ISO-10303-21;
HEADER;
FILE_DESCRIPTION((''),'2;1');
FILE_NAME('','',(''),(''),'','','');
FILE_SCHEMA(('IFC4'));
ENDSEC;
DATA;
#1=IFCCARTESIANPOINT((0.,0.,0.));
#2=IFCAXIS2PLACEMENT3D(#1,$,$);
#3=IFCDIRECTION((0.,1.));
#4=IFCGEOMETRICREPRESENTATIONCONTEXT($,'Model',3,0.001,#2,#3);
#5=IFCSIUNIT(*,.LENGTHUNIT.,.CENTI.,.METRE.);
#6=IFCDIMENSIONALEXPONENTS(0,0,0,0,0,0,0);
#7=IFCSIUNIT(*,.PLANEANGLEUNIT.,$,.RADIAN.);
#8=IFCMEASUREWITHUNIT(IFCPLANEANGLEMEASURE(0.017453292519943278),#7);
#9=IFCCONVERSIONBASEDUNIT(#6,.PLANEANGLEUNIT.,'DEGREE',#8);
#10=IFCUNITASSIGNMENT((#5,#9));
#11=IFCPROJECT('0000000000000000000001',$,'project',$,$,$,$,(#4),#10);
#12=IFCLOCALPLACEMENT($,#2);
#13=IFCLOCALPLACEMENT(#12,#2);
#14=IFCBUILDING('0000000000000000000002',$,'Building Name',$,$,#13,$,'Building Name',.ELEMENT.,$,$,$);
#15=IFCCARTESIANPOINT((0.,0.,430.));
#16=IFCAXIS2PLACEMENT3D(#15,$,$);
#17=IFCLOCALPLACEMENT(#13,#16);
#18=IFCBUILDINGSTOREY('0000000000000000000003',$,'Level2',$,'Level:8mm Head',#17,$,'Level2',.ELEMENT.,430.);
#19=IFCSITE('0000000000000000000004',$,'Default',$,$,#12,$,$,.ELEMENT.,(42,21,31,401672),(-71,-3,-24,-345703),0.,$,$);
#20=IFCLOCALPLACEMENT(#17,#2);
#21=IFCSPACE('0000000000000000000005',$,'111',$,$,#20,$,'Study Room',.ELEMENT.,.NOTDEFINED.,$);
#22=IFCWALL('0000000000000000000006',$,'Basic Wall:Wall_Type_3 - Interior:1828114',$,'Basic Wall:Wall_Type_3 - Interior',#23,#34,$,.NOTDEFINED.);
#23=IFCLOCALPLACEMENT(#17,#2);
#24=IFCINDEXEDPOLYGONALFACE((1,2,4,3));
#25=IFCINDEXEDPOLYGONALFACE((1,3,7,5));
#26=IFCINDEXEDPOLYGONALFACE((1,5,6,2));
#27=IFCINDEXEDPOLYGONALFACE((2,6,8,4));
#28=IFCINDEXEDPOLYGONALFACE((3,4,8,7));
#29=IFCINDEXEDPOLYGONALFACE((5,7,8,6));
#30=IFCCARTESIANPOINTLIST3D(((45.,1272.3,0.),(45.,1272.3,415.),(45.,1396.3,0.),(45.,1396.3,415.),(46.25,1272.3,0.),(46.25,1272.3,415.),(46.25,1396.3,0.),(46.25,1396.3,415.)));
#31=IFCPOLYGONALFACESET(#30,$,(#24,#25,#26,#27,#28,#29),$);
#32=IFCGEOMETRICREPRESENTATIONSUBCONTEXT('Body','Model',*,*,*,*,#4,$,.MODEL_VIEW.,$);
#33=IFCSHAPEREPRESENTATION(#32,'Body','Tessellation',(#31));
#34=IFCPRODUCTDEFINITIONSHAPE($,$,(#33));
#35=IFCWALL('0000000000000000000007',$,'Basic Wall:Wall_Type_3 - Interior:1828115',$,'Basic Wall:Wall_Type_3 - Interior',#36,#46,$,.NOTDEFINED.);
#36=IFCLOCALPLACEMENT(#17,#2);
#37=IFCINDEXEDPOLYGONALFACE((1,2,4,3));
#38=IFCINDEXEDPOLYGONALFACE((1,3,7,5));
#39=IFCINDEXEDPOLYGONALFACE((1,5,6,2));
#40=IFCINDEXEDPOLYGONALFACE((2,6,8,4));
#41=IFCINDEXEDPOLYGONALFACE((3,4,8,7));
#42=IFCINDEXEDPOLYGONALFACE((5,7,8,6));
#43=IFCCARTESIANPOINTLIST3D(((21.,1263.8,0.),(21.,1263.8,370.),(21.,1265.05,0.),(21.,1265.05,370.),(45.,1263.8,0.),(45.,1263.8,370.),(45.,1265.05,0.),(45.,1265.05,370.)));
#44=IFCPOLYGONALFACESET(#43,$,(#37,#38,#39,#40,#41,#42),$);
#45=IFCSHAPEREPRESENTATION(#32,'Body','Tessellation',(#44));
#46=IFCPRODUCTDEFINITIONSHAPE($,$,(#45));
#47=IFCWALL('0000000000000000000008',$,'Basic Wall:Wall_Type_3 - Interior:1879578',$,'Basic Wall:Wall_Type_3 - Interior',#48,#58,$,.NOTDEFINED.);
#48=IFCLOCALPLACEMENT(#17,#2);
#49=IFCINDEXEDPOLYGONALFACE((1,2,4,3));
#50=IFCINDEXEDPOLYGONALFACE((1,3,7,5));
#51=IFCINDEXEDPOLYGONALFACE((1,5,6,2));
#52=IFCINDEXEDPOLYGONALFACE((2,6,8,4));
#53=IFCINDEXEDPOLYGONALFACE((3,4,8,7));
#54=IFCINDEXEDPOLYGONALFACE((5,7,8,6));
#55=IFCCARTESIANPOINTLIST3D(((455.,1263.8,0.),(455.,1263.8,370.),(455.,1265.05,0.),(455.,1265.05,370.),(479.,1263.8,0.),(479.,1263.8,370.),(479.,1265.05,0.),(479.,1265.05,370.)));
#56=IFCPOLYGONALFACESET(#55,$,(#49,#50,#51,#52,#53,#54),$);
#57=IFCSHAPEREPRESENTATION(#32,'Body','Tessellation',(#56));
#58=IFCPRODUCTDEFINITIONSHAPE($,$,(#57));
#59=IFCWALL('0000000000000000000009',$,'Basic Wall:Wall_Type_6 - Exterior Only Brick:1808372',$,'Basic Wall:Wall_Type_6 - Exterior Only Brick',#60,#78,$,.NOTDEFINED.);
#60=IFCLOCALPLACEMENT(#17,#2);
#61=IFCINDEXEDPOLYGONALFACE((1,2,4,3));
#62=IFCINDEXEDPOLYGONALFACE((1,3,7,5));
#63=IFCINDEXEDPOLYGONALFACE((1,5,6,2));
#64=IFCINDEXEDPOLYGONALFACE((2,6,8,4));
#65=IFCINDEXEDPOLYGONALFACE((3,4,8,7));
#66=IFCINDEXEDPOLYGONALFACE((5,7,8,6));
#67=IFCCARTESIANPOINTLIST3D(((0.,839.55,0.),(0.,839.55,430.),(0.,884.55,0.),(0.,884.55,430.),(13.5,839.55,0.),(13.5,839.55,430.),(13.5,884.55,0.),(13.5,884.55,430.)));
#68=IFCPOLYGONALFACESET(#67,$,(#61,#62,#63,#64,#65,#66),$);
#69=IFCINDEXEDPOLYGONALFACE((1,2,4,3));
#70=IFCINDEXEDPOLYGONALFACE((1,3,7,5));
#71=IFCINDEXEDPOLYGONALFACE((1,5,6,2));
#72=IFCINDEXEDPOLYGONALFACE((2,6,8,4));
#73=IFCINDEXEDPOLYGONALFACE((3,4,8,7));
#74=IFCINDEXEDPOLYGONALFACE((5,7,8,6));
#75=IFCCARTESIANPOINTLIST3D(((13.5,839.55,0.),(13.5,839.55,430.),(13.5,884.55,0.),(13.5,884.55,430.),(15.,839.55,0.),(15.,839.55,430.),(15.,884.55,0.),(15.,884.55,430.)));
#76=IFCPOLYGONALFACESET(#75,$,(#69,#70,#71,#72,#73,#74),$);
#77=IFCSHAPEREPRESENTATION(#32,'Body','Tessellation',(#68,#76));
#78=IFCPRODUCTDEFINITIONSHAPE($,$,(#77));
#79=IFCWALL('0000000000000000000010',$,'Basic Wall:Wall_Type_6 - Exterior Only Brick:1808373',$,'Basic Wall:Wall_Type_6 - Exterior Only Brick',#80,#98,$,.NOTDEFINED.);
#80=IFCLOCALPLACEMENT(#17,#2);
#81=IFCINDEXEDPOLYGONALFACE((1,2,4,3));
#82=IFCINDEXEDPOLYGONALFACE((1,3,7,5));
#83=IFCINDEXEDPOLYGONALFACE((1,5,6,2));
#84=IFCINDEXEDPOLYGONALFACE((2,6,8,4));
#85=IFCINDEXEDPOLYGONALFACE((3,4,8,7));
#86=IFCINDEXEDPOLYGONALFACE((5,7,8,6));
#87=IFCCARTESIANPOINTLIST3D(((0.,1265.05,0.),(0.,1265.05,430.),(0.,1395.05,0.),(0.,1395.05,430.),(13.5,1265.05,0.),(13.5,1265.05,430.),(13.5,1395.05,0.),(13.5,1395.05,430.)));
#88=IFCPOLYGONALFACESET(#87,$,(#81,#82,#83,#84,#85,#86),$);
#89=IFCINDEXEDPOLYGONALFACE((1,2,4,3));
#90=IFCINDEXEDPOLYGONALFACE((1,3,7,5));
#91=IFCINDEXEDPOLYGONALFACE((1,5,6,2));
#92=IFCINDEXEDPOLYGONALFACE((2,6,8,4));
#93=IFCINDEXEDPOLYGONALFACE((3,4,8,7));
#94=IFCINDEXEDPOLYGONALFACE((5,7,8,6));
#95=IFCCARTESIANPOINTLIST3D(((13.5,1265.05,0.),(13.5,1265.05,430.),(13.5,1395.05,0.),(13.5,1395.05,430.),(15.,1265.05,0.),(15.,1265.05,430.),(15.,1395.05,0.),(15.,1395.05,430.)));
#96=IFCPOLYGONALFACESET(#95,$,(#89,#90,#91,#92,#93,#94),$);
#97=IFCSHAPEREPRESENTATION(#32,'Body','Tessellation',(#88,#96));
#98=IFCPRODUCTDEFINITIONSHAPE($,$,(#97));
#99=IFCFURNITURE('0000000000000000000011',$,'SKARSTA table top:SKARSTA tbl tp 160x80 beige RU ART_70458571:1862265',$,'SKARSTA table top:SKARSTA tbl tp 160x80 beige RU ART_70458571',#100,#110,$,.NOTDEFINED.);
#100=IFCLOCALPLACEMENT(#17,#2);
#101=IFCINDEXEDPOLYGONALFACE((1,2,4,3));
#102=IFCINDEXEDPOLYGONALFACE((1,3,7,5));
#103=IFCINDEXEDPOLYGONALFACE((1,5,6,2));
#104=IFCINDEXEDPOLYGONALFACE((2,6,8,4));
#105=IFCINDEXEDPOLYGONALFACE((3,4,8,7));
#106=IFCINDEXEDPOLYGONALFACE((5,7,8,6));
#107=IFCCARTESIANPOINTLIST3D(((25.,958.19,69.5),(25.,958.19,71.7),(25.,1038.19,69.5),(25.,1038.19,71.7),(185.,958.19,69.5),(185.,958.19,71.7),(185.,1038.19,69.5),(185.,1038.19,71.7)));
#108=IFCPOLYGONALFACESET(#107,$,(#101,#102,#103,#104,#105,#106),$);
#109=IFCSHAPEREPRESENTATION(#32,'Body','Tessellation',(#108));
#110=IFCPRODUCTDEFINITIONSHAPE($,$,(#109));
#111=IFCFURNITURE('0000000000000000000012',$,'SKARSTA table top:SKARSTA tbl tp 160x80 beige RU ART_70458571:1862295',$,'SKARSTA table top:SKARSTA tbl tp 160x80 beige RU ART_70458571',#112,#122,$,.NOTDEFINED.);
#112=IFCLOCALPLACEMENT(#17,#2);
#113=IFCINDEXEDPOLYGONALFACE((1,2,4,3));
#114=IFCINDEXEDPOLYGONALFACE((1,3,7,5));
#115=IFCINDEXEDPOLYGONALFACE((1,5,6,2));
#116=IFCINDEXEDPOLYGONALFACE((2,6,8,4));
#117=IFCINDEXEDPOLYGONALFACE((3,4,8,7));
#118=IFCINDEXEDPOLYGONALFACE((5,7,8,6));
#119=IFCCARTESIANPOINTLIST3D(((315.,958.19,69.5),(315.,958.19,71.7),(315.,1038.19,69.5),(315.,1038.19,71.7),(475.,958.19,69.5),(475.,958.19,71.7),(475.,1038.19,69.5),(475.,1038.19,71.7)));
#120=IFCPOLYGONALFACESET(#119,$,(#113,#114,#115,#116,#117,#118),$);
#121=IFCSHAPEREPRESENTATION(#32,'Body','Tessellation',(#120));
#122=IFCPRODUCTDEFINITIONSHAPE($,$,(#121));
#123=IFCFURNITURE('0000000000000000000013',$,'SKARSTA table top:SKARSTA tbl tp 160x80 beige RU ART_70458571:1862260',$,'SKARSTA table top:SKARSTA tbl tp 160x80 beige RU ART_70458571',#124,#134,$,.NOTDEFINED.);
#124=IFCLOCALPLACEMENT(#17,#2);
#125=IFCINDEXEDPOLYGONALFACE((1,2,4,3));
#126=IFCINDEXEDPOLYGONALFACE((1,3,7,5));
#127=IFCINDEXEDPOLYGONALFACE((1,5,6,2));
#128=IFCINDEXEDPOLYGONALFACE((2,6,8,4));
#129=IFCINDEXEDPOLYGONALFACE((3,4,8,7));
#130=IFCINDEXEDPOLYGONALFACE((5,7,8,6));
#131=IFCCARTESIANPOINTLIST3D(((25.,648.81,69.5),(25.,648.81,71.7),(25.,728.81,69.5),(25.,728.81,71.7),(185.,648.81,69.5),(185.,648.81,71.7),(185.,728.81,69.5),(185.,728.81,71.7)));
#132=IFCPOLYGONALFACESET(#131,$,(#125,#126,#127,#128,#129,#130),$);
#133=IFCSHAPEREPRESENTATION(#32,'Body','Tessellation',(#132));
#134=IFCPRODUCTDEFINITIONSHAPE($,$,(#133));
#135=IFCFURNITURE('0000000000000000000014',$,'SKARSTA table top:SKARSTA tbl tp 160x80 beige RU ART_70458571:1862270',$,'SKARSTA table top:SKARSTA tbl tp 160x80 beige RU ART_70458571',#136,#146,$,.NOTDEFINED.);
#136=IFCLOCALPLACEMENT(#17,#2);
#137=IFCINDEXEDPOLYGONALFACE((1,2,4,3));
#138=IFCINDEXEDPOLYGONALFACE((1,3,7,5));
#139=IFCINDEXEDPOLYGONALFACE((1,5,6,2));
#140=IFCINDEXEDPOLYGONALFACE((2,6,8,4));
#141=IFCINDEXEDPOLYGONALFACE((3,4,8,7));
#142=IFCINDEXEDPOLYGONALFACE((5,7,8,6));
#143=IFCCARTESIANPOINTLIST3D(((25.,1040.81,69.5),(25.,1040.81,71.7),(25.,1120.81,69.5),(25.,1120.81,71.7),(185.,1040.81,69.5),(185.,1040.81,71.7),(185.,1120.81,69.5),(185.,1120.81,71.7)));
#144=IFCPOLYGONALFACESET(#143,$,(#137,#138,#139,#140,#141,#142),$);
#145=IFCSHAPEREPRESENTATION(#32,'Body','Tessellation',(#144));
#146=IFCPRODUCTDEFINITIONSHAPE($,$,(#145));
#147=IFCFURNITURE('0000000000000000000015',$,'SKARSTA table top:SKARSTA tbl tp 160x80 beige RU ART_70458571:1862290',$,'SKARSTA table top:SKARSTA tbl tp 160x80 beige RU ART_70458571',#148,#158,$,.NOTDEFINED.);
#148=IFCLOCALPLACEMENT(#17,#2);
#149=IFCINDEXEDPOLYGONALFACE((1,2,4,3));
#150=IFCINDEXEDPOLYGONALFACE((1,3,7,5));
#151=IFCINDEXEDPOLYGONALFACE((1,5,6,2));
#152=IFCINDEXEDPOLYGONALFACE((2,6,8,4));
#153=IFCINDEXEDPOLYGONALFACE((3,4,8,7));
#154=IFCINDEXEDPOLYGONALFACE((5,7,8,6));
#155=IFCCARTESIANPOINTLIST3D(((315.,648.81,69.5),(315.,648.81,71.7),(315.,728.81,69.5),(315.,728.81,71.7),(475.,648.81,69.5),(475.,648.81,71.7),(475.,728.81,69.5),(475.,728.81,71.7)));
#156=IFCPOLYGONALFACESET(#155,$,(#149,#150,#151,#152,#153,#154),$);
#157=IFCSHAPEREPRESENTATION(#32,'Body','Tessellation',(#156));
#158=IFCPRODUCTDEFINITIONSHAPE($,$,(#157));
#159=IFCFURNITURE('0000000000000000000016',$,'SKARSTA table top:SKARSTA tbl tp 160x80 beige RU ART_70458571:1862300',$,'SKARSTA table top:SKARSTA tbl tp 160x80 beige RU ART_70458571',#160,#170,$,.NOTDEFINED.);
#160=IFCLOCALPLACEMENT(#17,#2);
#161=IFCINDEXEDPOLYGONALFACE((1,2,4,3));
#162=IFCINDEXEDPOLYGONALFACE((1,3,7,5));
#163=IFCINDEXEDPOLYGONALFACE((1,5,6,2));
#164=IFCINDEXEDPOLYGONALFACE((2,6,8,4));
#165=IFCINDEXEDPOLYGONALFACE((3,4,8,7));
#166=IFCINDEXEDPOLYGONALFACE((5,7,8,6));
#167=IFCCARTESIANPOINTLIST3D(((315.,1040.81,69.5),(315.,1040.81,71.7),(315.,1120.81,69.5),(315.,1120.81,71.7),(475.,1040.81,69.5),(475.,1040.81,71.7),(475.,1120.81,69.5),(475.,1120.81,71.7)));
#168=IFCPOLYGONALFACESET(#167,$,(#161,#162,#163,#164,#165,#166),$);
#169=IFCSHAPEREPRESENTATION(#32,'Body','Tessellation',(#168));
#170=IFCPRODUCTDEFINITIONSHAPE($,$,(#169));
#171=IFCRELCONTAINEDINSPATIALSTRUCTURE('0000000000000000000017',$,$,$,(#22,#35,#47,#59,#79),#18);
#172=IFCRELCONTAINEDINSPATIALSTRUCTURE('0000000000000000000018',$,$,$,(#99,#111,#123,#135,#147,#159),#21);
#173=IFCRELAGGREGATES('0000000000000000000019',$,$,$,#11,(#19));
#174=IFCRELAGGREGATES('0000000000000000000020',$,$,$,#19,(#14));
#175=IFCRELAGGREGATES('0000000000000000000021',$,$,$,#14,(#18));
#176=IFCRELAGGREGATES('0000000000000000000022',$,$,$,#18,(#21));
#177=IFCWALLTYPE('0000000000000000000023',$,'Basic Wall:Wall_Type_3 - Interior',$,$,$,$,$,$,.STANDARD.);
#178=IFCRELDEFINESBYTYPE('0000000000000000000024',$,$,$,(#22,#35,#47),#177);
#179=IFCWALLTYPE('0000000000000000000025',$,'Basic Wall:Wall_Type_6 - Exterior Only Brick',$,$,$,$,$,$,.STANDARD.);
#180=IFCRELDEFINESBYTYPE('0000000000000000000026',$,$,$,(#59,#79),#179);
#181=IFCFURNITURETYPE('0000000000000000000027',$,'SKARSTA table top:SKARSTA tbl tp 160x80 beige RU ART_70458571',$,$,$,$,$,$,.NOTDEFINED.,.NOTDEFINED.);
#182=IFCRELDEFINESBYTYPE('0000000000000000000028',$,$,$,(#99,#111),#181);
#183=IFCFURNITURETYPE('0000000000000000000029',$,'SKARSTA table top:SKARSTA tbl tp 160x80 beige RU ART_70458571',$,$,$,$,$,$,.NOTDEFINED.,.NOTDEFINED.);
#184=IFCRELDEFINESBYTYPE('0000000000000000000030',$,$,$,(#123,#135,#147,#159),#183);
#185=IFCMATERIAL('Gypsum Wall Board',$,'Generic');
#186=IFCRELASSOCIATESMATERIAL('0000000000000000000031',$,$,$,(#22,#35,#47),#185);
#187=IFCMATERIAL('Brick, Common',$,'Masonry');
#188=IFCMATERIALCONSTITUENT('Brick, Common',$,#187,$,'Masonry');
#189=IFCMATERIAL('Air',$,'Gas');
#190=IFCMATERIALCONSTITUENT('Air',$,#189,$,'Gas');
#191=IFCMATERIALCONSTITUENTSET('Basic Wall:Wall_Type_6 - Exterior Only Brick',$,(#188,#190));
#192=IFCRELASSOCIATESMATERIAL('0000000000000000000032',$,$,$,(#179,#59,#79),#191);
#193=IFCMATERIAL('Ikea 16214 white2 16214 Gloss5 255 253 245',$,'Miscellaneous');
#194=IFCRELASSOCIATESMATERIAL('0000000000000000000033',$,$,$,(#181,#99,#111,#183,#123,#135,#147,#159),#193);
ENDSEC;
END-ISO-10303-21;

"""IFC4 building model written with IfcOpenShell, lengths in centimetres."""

from ifc_helpers import new_model, entity, si_unit, converted_unit, direction, frame, origin, place, context, subcontext, project, spatial, indexed_curve, outline, extrude, source, transform, mapped, material, constituent, constituent_set, type_object, type_shapes, element, save


model = new_model("IFC4")

# Units and contexts
model_context = context("Model", 3, precision=0.001, world=origin(), true_north=direction((0.0, 1.0)))
body_context = subcontext(model_context, "Body", "Model", "MODEL_VIEW")
ifc_project = project(units=[si_unit("LENGTHUNIT", "METRE", prefix="CENTI"), converted_unit("PLANEANGLEUNIT", "DEGREE", entity("IfcPlaneAngleMeasure", 0.017453292519943278), si_unit("PLANEANGLEUNIT", "RADIAN"), dimensions=[0, 0, 0, 0, 0, 0, 0])], contexts=[model_context])

# Site, building, storey
site_placement = place(None, origin())
site = spatial("IfcSite", under=ifc_project, at=site_placement, Name="Default", CompositionType="ELEMENT", RefLatitude=(42, 21, 31, 401672), RefLongitude=(-71, -3, -24, -345703), RefElevation=0.0)
building_placement = place(site_placement, origin())
building = spatial("IfcBuilding", under=site, at=building_placement, Name="Building Name", LongName="Building Name", CompositionType="ELEMENT")
storey_placement = place(building_placement, frame((0.0, 0.0, 430.0)))
storey = spatial("IfcBuildingStorey", under=building, at=storey_placement, Name="Level2", ObjectType="Level:8mm Head", LongName="Level2", CompositionType="ELEMENT", Elevation=430.0)

# Shared definitions
ifc_material_1 = material(Name="Brick, Common", Category="Masonry")
ifc_material_2 = material(Name="Air", Category="Gas")
ifc_material_3 = material(Name="Gypsum Wall Board", Category="Generic")

# Walls
wall_type_1 = type_object("IfcWallType", Name="Basic Wall:Wall_Type_3 - Interior", PredefinedType="STANDARD")
wall_1_placement = place(storey_placement, frame((45.62, 1272.3, 0.0), z_axis=(0.0, 0.0, 1.0), x_axis=(0.0, 1.0, 0.0)))
element("IfcWall", 1, at=wall_1_placement, inside=storey, type_object=wall_type_1, material=ifc_material_3, Name="Basic Wall:Wall_Type_3 - Interior:1828114", ObjectType="Basic Wall:Wall_Type_3 - Interior", PredefinedType="NOTDEFINED", context=body_context, shape_type="SweptSolid", body=[
    extrude(outline(indexed_curve([(124.0, 0.62), (0.0, 0.62), (0.0, -0.62), (124.0, -0.63), (124.0, 0.62)], self_intersect=False)), origin(), (0.0, 0.0, 1.0), 415.0),
])
wall_2_placement = place(storey_placement, frame((21.0, 1264.42, 0.0)))
element("IfcWall", 2, at=wall_2_placement, inside=storey, type_object=wall_type_1, material=ifc_material_3, Name="Basic Wall:Wall_Type_3 - Interior:1828115", ObjectType="Basic Wall:Wall_Type_3 - Interior", PredefinedType="NOTDEFINED", context=body_context, shape_type="SweptSolid", body=[
    extrude(outline(indexed_curve([(24.0, 0.63), (0.0, 0.63), (0.0, -0.63), (24.0, -0.63), (24.0, 0.63)], self_intersect=False)), origin(), (0.0, 0.0, 1.0), 370.0),
])
wall_3_placement = place(storey_placement, frame((455.0, 1264.42, 0.0)))
element("IfcWall", 3, at=wall_3_placement, inside=storey, type_object=wall_type_1, material=ifc_material_3, Name="Basic Wall:Wall_Type_3 - Interior:1879578", ObjectType="Basic Wall:Wall_Type_3 - Interior", PredefinedType="NOTDEFINED", context=body_context, shape_type="SweptSolid", body=[
    extrude(outline(indexed_curve([(24.0, 0.63), (0.0, 0.63), (0.0, -0.63), (24.0, -0.63), (24.0, 0.63)], self_intersect=False)), origin(), (0.0, 0.0, 1.0), 370.0),
])
ifc_constituent_1 = constituent(ifc_material_1, Name="Brick, Common", Category="Masonry")
ifc_constituent_2 = constituent(ifc_material_2, Name="Air", Category="Gas")
ifc_constituent_set_1 = constituent_set(constituents=[ifc_constituent_1, ifc_constituent_2], Name="Basic Wall:Wall_Type_6 - Exterior Only Brick")
wall_type_2 = type_object("IfcWallType", Name="Basic Wall:Wall_Type_6 - Exterior Only Brick", PredefinedType="STANDARD", material=ifc_constituent_set_1)
wall_4_placement = place(storey_placement, frame((7.5, 839.55, 0.0), z_axis=(0.0, 0.0, 1.0), x_axis=(0.0, 1.0, 0.0)))
element("IfcWall", 4, at=wall_4_placement, inside=storey, type_object=wall_type_2, material=ifc_constituent_set_1, Name="Basic Wall:Wall_Type_6 - Exterior Only Brick:1808372", ObjectType="Basic Wall:Wall_Type_6 - Exterior Only Brick", PredefinedType="NOTDEFINED", context=body_context, shape_type="SweptSolid", body=[
    extrude(outline(indexed_curve([(-6.75, -22.5), (6.75, -22.5), (6.75, 22.5), (-6.75, 22.5), (-6.75, -22.5)], self_intersect=False)), frame((22.5, 0.75, 0.0), z_axis=(0.0, 0.0, 1.0), x_axis=(0.0, -1.0, 0.0)), (0.0, 0.0, 1.0), 430.0),
    extrude(outline(indexed_curve([(-0.75, -22.5), (0.75, -22.5), (0.75, 22.5), (-0.75, 22.5), (-0.75, -22.5)], self_intersect=False)), frame((22.5, -6.75, 0.0), z_axis=(0.0, 0.0, 1.0), x_axis=(0.0, 1.0, 0.0)), (0.0, 0.0, 1.0), 430.0),
])
wall_5_placement = place(storey_placement, frame((7.5, 1265.05, 0.0), z_axis=(0.0, 0.0, 1.0), x_axis=(0.0, 1.0, 0.0)))
element("IfcWall", 5, at=wall_5_placement, inside=storey, type_object=wall_type_2, material=ifc_constituent_set_1, Name="Basic Wall:Wall_Type_6 - Exterior Only Brick:1808373", ObjectType="Basic Wall:Wall_Type_6 - Exterior Only Brick", PredefinedType="NOTDEFINED", context=body_context, shape_type="SweptSolid", body=[
    extrude(outline(indexed_curve([(-6.75, -65.0), (6.75, -65.0), (6.75, 65.0), (-6.75, 65.0), (-6.75, -65.0)], self_intersect=False)), frame((65.0, 0.75, 0.0), z_axis=(0.0, 0.0, 1.0), x_axis=(0.0, -1.0, 0.0)), (0.0, 0.0, 1.0), 430.0),
    extrude(outline(indexed_curve([(-0.75, -65.0), (0.75, -65.0), (0.75, 65.0), (-0.75, 65.0), (-0.75, -65.0)], self_intersect=False)), frame((65.0, -6.75, 0.0), z_axis=(0.0, 0.0, 1.0), x_axis=(0.0, 1.0, 0.0)), (0.0, 0.0, 1.0), 430.0),
])

# Shared definitions
space_placement = place(storey_placement, origin())
space = spatial("IfcSpace", under=storey, at=space_placement, Name="111", LongName="Study Room", CompositionType="ELEMENT", PredefinedType="NOTDEFINED")

# Furniture
ifc_material_4 = material(Name="Ikea 16214 white2 16214 Gloss5 255 253 245", Category="Miscellaneous")
furniture_type_1 = type_object("IfcFurnitureType", Name="SKARSTA table top:SKARSTA tbl tp 160x80 beige RU ART_70458571", AssemblyPlace="NOTDEFINED", PredefinedType="NOTDEFINED", material=ifc_material_4)
shared_shape_1 = source(origin(), body_context, "Body", "SweptSolid", [
    extrude(outline(indexed_curve([(-40.0, -80.0), (40.0, -80.0), (40.0, 80.0), (-40.0, 80.0), (-40.0, -80.0)], self_intersect=False)), frame((0.0, 0.0, 0.0), z_axis=(0.0, 0.0, 1.0), x_axis=(0.0, 1.0, 0.0)), (0.0, 0.0, 1.0), 2.2),
])
type_shapes(furniture_type_1, [shared_shape_1])
for number, where, z_axis, x_axis, name in (
    (6, (105.0, 998.19, 69.5), (0.0, 0.0, 1.0), (-1.0, 0.0, 0.0), "SKARSTA table top:SKARSTA tbl tp 160x80 beige RU ART_70458571:1862265"),
    (7, (395.0, 998.19, 69.5), (0.0, 0.0, 1.0), (-1.0, 0.0, 0.0), "SKARSTA table top:SKARSTA tbl tp 160x80 beige RU ART_70458571:1862295"),
):
    element("IfcFurniture", number, at=place(space_placement, frame(where, z_axis=z_axis, x_axis=x_axis)), inside=space, type_object=furniture_type_1, material=ifc_material_4, Name=name, ObjectType="SKARSTA table top:SKARSTA tbl tp 160x80 beige RU ART_70458571", PredefinedType="NOTDEFINED", context=body_context, shape_type="MappedRepresentation", body=[
        mapped(shared_shape_1, transform((0.0, 0.0, 0.0), scale=1.0)),
    ])
furniture_type_2 = type_object("IfcFurnitureType", Name="SKARSTA table top:SKARSTA tbl tp 160x80 beige RU ART_70458571", AssemblyPlace="NOTDEFINED", PredefinedType="NOTDEFINED", material=ifc_material_4)
shared_shape_2 = source(origin(), body_context, "Body", "SweptSolid", [
    extrude(outline(indexed_curve([(-80.0, -40.0), (80.0, -40.0), (80.0, 40.0), (-80.0, 40.0), (-80.0, -40.0)], self_intersect=False)), frame((0.0, 0.0, 0.0), z_axis=(0.0, 0.0, 1.0), x_axis=(-1.0, 0.0, 0.0)), (0.0, 0.0, 1.0), 2.2),
])
type_shapes(furniture_type_2, [shared_shape_2])
for number, where, z_axis, x_axis, name in (
    (8, (105.0, 688.81, 69.5), (0.0, 0.0, 1.0), (-1.0, 0.0, 0.0), "SKARSTA table top:SKARSTA tbl tp 160x80 beige RU ART_70458571:1862260"),
    (9, (105.0, 1080.81, 69.5), (0.0, 0.0, 1.0), (-1.0, 0.0, 0.0), "SKARSTA table top:SKARSTA tbl tp 160x80 beige RU ART_70458571:1862270"),
    (10, (395.0, 688.81, 69.5), (0.0, 0.0, 1.0), (-1.0, 0.0, 0.0), "SKARSTA table top:SKARSTA tbl tp 160x80 beige RU ART_70458571:1862290"),
    (11, (395.0, 1080.81, 69.5), (0.0, 0.0, 1.0), (-1.0, 0.0, 0.0), "SKARSTA table top:SKARSTA tbl tp 160x80 beige RU ART_70458571:1862300"),
):
    element("IfcFurniture", number, at=place(space_placement, frame(where, z_axis=z_axis, x_axis=x_axis)), inside=space, type_object=furniture_type_2, material=ifc_material_4, Name=name, ObjectType="SKARSTA table top:SKARSTA tbl tp 160x80 beige RU ART_70458571", PredefinedType="NOTDEFINED", context=body_context, shape_type="MappedRepresentation", body=[
        mapped(shared_shape_2, transform((0.0, 0.0, 0.0), scale=1.0)),
    ])

save(model, "model.ifc")
